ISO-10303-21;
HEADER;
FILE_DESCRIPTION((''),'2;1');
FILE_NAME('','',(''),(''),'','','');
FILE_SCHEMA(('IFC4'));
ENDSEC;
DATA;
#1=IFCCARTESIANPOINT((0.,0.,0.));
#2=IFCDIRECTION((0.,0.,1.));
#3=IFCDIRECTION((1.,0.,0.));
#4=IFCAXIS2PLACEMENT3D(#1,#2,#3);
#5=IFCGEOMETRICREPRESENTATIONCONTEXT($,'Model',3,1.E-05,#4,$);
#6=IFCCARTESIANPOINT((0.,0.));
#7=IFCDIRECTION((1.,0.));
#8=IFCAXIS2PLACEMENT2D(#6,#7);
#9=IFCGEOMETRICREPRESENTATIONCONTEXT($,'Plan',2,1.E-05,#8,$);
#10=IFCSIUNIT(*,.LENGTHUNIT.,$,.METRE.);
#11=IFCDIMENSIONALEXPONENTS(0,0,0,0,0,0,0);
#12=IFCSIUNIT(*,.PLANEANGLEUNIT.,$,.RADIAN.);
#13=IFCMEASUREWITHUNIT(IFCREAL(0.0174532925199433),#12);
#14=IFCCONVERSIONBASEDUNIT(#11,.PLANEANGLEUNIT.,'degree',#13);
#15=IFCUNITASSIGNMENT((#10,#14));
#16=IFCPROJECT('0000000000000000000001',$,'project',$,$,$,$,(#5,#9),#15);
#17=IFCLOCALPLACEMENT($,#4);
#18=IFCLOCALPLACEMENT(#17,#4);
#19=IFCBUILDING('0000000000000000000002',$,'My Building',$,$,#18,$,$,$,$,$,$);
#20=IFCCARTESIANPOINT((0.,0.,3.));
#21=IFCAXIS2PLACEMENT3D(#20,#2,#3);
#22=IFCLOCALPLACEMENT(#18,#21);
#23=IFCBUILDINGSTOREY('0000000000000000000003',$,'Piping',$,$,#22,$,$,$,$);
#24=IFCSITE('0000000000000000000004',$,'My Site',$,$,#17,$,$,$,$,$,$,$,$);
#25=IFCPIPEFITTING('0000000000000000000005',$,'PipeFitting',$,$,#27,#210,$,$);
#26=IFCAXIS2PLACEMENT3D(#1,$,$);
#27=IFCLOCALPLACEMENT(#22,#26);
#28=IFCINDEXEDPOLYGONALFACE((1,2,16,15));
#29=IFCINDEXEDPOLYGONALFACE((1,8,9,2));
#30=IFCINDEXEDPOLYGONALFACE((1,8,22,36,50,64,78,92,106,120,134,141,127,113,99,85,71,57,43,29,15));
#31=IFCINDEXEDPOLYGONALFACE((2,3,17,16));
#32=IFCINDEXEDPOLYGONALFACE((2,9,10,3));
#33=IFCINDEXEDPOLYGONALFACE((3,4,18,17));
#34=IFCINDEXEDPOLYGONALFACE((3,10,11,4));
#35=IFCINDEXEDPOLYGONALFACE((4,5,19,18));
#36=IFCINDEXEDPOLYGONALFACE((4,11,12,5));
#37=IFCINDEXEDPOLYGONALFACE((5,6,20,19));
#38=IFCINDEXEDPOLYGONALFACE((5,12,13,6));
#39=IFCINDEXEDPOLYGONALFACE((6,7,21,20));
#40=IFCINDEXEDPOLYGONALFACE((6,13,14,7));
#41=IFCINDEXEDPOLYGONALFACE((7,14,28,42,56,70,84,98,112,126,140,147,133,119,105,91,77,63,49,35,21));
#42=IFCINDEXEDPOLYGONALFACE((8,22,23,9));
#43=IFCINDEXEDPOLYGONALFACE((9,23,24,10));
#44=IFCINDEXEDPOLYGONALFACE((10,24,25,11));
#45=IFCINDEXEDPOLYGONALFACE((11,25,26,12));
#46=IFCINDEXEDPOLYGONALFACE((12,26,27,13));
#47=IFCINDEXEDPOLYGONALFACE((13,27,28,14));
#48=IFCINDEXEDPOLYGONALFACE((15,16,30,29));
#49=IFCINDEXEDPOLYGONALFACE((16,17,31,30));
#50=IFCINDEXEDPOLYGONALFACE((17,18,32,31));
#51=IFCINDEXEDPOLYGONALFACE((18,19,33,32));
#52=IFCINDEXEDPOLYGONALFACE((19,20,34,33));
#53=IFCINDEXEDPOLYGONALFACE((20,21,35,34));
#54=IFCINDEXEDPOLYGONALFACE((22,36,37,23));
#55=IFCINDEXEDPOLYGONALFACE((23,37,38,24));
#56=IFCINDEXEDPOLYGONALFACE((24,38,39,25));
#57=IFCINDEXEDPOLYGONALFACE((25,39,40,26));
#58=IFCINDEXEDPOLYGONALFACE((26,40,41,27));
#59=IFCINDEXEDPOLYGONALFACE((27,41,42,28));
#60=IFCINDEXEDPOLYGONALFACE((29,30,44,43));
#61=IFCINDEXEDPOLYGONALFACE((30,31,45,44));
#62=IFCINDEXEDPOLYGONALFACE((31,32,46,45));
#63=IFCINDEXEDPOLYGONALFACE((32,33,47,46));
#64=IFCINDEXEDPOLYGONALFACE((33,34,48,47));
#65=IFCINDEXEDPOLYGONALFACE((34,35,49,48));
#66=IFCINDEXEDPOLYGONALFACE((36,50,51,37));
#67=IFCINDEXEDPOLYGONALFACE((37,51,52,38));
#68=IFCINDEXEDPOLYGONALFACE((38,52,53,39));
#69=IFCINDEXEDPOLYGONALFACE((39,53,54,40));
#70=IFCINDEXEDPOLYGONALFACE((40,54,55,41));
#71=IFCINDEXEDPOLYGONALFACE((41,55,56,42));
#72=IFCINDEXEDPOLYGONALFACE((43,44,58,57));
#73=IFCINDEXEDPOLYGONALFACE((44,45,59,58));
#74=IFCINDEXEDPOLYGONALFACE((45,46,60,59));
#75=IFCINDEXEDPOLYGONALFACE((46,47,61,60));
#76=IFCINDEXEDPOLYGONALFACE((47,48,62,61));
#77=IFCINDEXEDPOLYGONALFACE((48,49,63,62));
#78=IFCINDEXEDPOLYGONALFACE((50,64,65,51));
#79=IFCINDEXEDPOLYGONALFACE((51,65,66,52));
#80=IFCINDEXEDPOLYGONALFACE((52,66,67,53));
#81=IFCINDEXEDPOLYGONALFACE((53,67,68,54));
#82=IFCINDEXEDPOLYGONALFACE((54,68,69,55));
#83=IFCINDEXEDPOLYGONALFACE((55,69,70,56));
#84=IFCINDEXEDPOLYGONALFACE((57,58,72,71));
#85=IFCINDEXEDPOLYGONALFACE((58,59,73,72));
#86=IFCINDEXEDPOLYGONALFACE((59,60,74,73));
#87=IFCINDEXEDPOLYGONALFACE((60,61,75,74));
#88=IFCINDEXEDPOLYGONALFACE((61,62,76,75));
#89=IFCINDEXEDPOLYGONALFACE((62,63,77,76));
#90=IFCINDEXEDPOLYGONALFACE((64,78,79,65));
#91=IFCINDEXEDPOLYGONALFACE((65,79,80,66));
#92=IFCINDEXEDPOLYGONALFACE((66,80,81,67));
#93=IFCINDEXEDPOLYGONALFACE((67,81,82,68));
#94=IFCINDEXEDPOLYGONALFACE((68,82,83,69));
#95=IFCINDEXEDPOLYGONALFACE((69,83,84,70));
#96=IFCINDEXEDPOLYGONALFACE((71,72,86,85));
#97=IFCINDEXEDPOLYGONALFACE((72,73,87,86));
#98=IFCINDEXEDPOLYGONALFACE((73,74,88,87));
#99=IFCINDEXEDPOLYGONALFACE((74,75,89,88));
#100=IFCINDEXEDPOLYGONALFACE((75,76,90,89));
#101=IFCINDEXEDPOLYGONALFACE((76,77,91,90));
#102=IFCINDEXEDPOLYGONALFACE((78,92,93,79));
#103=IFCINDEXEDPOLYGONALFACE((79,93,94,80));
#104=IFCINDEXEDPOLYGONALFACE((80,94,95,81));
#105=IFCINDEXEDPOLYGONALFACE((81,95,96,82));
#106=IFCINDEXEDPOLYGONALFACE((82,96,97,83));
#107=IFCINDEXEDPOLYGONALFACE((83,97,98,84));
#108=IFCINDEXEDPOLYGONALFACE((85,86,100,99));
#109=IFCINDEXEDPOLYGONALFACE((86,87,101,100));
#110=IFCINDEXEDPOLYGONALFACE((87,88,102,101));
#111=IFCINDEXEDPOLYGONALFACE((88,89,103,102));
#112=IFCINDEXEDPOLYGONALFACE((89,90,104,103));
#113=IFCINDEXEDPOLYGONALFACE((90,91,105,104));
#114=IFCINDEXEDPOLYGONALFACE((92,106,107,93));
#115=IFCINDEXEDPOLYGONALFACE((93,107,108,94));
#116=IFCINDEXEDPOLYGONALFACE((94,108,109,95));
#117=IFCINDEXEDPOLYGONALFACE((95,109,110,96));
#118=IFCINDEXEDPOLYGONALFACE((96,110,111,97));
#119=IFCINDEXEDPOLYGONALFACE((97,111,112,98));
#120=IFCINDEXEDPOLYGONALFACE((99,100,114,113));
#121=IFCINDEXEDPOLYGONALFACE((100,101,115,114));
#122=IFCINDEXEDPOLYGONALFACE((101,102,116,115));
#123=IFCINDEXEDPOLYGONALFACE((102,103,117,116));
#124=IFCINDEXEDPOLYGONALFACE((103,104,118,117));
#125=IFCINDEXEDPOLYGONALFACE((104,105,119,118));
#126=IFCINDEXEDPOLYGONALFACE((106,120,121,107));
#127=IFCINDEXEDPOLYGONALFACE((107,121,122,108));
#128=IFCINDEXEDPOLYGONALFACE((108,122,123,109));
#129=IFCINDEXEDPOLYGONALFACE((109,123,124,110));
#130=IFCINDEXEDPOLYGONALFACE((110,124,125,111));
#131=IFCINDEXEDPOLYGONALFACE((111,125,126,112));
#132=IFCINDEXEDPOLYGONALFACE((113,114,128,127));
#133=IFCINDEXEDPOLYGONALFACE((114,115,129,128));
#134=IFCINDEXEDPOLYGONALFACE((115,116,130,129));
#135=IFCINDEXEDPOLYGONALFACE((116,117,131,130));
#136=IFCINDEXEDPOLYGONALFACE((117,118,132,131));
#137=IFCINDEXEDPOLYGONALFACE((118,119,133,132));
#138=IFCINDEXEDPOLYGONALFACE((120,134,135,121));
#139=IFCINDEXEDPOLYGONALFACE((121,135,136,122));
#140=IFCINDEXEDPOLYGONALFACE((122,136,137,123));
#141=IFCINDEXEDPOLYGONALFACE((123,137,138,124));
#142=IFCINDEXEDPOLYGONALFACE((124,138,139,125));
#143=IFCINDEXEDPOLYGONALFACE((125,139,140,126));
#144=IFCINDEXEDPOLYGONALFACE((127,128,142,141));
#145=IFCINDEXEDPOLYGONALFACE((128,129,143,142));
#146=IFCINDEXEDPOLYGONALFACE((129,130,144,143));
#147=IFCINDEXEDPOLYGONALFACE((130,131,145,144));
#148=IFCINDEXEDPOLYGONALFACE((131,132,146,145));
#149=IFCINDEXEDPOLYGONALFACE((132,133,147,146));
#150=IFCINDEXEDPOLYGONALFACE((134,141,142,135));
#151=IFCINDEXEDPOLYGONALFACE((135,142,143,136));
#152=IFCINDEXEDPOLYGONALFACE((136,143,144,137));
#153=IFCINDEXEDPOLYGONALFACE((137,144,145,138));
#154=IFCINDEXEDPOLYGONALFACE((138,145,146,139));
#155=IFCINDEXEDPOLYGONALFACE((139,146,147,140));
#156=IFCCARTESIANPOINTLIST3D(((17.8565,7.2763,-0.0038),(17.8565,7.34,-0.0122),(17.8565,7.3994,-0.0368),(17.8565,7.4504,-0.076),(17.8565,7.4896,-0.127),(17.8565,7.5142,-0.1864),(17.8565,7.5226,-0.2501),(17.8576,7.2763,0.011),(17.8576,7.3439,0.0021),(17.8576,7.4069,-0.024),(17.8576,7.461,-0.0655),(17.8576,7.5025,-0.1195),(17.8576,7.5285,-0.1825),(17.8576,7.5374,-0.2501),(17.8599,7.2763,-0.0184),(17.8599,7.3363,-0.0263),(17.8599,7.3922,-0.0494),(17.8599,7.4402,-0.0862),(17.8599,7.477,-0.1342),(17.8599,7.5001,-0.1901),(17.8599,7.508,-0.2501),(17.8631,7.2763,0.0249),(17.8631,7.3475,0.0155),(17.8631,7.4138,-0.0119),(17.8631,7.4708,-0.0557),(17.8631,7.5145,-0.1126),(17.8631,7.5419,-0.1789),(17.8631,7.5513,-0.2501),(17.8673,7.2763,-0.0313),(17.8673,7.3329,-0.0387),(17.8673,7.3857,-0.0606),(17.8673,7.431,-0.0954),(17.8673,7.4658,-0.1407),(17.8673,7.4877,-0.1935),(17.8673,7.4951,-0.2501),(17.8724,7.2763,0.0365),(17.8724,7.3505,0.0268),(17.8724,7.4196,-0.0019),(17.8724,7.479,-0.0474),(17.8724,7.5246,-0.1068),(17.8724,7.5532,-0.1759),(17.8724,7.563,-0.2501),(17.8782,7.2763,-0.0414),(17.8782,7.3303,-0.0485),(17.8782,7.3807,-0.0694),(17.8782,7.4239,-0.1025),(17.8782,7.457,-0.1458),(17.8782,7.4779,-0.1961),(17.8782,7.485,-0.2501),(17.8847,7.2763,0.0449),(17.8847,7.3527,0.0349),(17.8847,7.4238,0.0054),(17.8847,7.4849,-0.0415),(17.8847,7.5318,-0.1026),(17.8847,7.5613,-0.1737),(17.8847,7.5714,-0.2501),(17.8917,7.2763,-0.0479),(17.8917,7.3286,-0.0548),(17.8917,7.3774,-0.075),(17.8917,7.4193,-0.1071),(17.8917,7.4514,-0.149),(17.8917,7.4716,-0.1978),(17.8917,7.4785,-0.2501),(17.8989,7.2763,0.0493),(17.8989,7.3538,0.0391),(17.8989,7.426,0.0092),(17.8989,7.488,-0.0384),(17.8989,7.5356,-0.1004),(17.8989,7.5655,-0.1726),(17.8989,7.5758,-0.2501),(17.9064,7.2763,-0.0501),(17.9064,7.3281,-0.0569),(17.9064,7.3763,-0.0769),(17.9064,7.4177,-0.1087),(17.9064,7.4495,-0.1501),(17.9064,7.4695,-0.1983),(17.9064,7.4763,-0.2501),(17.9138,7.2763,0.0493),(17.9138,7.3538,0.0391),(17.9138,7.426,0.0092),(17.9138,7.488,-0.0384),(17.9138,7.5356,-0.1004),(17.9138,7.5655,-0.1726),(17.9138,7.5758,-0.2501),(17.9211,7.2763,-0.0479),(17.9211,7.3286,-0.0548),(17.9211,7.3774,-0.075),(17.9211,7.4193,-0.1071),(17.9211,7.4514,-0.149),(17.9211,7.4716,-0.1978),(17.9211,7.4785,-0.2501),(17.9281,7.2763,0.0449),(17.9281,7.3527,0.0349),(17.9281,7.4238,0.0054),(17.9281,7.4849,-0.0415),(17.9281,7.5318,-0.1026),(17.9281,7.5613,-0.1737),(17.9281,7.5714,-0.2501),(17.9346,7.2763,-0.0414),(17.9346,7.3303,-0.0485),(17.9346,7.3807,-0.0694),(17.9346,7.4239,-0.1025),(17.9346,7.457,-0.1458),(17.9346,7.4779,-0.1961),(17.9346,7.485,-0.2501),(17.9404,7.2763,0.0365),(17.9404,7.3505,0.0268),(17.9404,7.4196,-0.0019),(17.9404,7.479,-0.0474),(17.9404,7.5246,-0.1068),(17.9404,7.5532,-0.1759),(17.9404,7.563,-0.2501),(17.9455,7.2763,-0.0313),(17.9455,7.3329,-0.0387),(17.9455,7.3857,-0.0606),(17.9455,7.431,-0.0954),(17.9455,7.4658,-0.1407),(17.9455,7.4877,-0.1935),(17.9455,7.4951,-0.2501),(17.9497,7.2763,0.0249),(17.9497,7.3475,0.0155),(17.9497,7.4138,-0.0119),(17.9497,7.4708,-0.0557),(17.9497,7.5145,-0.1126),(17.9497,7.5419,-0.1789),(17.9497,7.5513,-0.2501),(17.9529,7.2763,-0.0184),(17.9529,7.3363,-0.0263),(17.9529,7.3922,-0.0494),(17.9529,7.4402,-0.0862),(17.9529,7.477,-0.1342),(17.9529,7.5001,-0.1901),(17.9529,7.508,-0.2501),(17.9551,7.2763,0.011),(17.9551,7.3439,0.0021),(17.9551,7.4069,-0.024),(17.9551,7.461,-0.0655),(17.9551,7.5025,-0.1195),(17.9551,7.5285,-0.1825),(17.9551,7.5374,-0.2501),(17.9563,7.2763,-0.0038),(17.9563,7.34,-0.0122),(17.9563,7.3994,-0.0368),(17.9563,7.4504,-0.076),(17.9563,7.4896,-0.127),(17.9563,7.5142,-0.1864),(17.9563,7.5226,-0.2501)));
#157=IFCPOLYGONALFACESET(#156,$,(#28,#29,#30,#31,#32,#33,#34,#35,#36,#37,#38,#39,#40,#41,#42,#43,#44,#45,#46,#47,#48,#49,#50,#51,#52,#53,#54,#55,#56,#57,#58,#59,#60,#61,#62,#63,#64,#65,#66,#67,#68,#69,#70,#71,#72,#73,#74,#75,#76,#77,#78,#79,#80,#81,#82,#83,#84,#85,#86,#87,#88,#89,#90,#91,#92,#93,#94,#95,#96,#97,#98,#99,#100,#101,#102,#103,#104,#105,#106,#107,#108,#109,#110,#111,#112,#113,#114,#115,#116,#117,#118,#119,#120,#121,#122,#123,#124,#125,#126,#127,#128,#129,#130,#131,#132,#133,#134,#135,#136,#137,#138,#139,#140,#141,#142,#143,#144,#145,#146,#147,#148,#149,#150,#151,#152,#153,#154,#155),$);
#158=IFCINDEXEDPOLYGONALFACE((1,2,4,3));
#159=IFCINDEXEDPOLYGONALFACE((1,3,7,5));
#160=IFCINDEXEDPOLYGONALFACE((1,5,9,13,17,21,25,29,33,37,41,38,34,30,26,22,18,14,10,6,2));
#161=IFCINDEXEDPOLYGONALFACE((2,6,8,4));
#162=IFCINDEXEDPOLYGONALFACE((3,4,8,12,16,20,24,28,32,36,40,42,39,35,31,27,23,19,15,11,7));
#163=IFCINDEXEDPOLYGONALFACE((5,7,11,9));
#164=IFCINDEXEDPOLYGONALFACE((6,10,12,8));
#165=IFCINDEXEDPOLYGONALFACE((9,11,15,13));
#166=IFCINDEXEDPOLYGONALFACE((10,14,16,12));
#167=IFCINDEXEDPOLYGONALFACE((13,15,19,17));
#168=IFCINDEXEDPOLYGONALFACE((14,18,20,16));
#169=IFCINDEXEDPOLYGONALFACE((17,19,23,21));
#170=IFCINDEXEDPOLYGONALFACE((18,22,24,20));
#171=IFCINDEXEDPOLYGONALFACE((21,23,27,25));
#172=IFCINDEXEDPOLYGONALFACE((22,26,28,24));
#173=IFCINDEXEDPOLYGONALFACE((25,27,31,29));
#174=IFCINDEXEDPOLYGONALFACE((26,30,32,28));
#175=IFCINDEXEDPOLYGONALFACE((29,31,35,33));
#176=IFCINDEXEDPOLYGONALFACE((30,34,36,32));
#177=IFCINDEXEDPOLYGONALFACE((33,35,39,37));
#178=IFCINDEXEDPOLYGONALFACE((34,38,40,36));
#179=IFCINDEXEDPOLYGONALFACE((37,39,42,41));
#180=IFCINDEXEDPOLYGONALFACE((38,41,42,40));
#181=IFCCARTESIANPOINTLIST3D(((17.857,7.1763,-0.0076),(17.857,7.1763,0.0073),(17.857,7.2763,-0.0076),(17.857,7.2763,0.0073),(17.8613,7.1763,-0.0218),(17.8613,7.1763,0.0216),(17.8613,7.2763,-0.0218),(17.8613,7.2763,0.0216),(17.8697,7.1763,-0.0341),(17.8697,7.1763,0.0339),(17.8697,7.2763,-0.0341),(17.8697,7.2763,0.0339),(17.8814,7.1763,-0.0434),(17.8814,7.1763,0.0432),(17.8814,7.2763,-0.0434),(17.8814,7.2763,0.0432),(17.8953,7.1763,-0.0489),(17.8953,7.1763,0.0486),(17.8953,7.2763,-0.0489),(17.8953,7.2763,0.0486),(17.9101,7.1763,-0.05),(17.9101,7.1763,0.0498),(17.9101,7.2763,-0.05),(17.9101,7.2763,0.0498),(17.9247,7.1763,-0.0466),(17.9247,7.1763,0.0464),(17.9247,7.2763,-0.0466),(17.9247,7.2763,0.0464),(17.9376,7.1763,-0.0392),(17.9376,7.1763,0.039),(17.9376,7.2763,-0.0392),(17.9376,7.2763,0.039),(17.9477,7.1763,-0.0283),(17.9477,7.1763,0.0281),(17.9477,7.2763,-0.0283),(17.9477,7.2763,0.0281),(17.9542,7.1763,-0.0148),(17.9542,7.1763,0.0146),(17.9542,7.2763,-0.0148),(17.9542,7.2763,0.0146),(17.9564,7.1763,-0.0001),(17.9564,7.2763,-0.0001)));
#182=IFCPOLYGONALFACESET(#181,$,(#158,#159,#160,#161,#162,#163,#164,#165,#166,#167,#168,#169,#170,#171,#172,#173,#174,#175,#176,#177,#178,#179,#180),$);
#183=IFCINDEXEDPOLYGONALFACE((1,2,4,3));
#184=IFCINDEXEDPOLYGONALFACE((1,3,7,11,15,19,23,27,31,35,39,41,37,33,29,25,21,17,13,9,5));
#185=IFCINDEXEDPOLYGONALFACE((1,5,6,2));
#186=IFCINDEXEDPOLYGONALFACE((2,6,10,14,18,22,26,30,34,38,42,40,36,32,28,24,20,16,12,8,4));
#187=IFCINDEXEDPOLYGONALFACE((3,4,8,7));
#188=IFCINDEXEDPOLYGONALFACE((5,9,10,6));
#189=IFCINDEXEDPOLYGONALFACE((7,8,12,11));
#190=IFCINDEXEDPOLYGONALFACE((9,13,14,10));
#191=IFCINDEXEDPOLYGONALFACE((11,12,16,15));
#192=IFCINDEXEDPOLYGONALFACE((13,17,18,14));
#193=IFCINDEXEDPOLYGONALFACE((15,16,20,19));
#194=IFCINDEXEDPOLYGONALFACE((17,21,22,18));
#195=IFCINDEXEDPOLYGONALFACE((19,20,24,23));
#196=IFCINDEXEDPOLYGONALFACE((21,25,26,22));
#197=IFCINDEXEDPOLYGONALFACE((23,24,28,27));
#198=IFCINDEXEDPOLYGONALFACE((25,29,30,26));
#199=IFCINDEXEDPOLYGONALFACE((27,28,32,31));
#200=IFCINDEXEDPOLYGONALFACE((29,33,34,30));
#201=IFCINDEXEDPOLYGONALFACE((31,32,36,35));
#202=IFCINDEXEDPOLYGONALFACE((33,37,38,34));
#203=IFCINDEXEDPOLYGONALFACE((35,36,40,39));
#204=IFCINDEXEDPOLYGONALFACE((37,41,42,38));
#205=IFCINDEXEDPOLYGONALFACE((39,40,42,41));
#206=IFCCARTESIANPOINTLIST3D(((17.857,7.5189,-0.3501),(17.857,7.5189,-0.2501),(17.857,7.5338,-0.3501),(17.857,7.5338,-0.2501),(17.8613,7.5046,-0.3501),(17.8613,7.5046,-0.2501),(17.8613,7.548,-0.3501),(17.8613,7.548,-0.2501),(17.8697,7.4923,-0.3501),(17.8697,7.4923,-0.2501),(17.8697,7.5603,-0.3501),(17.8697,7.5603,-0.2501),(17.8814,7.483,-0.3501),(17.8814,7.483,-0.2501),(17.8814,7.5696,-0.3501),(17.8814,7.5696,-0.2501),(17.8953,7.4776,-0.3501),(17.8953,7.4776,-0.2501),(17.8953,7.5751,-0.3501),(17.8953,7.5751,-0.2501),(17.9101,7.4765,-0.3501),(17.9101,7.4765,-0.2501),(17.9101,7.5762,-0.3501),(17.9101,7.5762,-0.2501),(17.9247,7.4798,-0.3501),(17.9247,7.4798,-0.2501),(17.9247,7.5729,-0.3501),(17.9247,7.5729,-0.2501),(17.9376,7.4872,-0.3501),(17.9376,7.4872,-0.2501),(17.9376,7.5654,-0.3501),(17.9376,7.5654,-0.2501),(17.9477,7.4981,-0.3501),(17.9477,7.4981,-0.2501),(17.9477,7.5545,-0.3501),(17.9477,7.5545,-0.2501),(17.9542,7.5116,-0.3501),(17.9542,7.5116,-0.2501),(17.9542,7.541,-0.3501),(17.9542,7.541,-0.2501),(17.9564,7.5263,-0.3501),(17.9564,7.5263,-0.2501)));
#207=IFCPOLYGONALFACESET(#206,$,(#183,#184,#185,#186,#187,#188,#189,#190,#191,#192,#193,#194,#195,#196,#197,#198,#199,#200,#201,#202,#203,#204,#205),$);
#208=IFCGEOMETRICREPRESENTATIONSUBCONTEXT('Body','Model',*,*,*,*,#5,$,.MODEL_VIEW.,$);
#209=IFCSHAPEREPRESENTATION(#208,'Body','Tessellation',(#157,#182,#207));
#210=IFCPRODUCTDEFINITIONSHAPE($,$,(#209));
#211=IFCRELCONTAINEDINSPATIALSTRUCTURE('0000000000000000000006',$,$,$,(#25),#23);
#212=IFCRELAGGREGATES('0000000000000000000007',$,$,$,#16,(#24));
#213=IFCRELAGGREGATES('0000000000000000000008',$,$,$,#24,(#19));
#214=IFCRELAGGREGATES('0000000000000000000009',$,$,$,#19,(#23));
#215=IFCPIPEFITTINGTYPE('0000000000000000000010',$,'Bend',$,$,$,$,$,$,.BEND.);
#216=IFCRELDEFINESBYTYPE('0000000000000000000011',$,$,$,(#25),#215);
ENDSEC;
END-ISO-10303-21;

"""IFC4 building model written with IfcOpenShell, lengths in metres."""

from ifc_helpers import new_model, entity, si_unit, converted_unit, frame, origin_with_axes, origin_2d_with_axis, place, context, subcontext, project, spatial, circle, extrude, source, transform, mapped, type_object, type_shapes, element, save


model = new_model("IFC4")

# Units and contexts
model_context = context("Model", 3, precision=1e-05, world=origin_with_axes())
plan_context = context("Plan", 2, precision=1e-05, world=origin_2d_with_axis())
body_context = subcontext(model_context, "Body", "Model", "MODEL_VIEW")
ifc_project = project(units=[si_unit("LENGTHUNIT", "METRE"), converted_unit("PLANEANGLEUNIT", "degree", entity("IfcReal", 0.0174532925199433), si_unit("PLANEANGLEUNIT", "RADIAN"), dimensions=[0, 0, 0, 0, 0, 0, 0])], contexts=[model_context, plan_context])

# Site, building, storey
site_placement = place(None, origin_with_axes())
site = spatial("IfcSite", under=ifc_project, at=site_placement, Name="My Site")
building_placement = place(site_placement, origin_with_axes())
building = spatial("IfcBuilding", under=site, at=building_placement, Name="My Building")
storey_placement = place(building_placement, frame((0.0, 0.0, 3.0), z_axis=(0.0, 0.0, 1.0), x_axis=(1.0, 0.0, 0.0)))
storey = spatial("IfcBuildingStorey", under=building, at=storey_placement, Name="Piping")

# Pipe fitting
pipe_fitting_type = type_object("IfcPipeFittingType", Name="Bend", PredefinedType="BEND")
shared_shape = source(origin_with_axes(), body_context, "Body", "SolidModel", [
    entity("IfcSweptDiskSolid", entity("IfcIndexedPolyCurve", entity("IfcCartesianPointList3D", [[0.0, 0.0, -0.1], [0.0, -0.0732, -0.2768], [0.0, -0.25, -0.35]]), [entity("IfcArcIndex", [1, 2, 3])]), 0.05),
    extrude(circle(Radius=0.05), origin_with_axes(), (0.0, 0.0, -1.0), 0.1),
    extrude(circle(Radius=0.05), frame((0.0, -0.25, -0.35), z_axis=(0.0, -1.0, 0.0), x_axis=(1.0, 0.0, 0.0)), (0.0, 0.0, 1.0), 0.1),
])
type_shapes(pipe_fitting_type, [shared_shape])
for number, where, z_axis, x_axis, name in (
    (1, (17.9064, 7.1763, -0.0001), (0.0, -1.0, 0.0), (1.0, 0.0, 0.0), "PipeFitting"),
):
    element("IfcPipeFitting", number, at=place(storey_placement, frame(where, z_axis=z_axis, x_axis=x_axis)), inside=storey, type_object=pipe_fitting_type, Name=name, context=body_context, shape_type="MappedRepresentation", body=[
        mapped(shared_shape, transform((0.0, 0.0, 0.0), x_axis=(1.0, 0.0, 0.0), y_axis=(0.0, 1.0, 0.0), z_axis=(0.0, 0.0, 1.0), scale=1.0)),
    ])

save(model, "model.ifc")
